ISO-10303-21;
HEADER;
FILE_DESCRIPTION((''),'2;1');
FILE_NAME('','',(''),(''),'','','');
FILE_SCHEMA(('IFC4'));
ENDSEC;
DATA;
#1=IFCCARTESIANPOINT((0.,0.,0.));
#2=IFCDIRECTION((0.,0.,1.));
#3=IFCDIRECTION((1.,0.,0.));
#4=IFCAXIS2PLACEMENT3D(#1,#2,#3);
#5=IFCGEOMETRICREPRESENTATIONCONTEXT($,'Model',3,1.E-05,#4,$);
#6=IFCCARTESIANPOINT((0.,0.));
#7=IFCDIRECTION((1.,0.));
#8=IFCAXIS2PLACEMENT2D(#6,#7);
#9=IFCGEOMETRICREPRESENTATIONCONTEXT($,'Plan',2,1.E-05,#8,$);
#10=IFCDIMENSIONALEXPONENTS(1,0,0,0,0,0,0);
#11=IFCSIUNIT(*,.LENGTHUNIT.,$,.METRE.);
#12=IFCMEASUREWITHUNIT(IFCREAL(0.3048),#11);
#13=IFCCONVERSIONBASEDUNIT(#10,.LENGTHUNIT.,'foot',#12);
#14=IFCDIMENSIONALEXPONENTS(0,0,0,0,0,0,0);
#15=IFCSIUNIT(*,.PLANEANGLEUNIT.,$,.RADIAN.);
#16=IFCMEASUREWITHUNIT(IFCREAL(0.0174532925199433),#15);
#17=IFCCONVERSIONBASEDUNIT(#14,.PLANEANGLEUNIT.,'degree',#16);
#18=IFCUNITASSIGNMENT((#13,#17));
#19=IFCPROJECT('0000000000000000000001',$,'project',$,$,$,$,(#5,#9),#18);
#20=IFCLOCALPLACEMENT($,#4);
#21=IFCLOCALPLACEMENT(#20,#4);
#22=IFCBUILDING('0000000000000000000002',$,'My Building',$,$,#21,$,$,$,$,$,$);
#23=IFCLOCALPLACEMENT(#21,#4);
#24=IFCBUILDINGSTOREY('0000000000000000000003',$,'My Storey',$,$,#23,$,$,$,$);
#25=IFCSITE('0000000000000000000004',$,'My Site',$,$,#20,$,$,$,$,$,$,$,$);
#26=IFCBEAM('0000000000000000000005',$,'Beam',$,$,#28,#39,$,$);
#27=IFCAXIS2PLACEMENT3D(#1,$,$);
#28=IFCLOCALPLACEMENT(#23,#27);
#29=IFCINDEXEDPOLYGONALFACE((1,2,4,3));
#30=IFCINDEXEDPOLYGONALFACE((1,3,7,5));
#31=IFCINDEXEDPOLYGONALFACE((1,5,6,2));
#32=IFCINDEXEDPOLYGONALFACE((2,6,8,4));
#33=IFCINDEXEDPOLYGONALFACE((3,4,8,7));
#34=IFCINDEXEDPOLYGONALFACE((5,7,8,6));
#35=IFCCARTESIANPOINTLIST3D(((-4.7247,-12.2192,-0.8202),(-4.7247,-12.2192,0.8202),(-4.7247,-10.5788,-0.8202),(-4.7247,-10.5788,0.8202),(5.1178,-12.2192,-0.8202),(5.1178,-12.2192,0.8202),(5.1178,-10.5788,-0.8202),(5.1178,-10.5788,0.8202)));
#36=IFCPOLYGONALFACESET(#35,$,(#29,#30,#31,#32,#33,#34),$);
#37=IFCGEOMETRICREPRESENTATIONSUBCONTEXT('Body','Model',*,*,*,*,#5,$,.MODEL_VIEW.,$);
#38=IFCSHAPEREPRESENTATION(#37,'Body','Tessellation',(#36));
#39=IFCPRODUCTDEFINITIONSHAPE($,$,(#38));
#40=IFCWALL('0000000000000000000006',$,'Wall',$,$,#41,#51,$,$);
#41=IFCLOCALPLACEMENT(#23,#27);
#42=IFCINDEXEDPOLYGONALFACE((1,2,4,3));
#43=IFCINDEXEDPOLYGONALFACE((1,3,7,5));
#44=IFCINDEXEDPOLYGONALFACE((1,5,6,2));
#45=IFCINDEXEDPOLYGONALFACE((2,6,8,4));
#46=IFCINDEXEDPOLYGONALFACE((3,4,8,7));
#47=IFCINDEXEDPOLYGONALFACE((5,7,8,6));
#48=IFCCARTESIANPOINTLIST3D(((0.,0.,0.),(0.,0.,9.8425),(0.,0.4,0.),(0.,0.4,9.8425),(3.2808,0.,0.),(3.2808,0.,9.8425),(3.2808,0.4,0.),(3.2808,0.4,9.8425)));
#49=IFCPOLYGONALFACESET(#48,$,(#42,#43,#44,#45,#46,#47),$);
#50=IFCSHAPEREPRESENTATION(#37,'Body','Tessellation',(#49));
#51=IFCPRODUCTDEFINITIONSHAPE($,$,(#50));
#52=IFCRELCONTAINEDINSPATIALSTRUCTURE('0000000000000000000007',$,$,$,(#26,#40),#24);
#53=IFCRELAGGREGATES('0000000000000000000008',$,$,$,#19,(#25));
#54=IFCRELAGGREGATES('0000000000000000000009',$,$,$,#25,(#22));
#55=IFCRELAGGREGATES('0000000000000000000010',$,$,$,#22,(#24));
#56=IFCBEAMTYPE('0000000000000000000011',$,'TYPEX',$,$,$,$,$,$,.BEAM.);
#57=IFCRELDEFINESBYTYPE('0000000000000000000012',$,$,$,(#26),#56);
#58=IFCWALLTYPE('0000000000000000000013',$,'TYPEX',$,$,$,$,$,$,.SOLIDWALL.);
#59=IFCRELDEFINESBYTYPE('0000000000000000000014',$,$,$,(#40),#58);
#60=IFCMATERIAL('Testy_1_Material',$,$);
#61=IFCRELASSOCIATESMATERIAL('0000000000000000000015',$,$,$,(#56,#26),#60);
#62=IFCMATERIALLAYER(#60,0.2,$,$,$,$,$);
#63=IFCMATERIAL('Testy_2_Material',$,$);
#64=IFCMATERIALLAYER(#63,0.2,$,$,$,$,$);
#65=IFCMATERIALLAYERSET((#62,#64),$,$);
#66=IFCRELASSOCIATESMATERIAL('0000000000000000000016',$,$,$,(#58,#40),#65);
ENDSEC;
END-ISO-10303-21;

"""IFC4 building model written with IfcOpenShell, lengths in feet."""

from ifc_helpers import new_model, entity, si_unit, converted_unit, frame, origin_with_axes, origin_2d_with_axis, place, context, subcontext, project, spatial, indexed_curve, rectangle, outline, extrude, material, layer, layer_set, layer_usage, material_profile, profile_set, profile_usage, type_object, element, save


model = new_model("IFC4")

# Units and contexts
model_context = context("Model", 3, precision=1e-05, world=origin_with_axes())
plan_context = context("Plan", 2, precision=1e-05, world=origin_2d_with_axis())
body_context = subcontext(model_context, "Body", "Model", "MODEL_VIEW")
ifc_project = project(units=[converted_unit("LENGTHUNIT", "foot", entity("IfcReal", 0.3048), si_unit("LENGTHUNIT", "METRE"), dimensions=[1, 0, 0, 0, 0, 0, 0]), converted_unit("PLANEANGLEUNIT", "degree", entity("IfcReal", 0.0174532925199433), si_unit("PLANEANGLEUNIT", "RADIAN"), dimensions=[0, 0, 0, 0, 0, 0, 0])], contexts=[model_context, plan_context])

# Site, building, storey
site_placement = place(None, origin_with_axes())
site = spatial("IfcSite", under=ifc_project, at=site_placement, Name="My Site")
building_placement = place(site_placement, origin_with_axes())
building = spatial("IfcBuilding", under=site, at=building_placement, Name="My Building")
storey_placement = place(building_placement, origin_with_axes())
storey = spatial("IfcBuildingStorey", under=building, at=storey_placement, Name="My Storey")

# Beam
ifc_material_1 = material(Name="Testy_1_Material")
ifc_material_profile = material_profile(ifc_material_1, rectangle(XDim=1.6404, YDim=1.6404))
ifc_profile_set = profile_set([ifc_material_profile])
ifc_profile_usage = profile_usage(ifc_profile_set, cardinal=5)
beam_type = type_object("IfcBeamType", Name="TYPEX", PredefinedType="BEAM", material=ifc_profile_set)
beam_placement = place(storey_placement, frame((-4.7247, -11.399, 0.0), z_axis=(1.0, 0.0, 0.0), x_axis=(0.0, 1.0, 0.0)))
element("IfcBeam", 1, at=beam_placement, inside=storey, type_object=beam_type, material=ifc_profile_usage, Name="Beam", context=body_context, shape_type="SweptSolid", body=[
    extrude(rectangle(XDim=1.6404, YDim=1.6404), origin_with_axes(), (0.0, 0.0, 1.0), 9.8425),
])

# Wall
ifc_layer_1 = layer(ifc_material_1, 0.2)
ifc_material_2 = material(Name="Testy_2_Material")
ifc_layer_2 = layer(ifc_material_2, 0.2)
ifc_layer_set = layer_set([ifc_layer_1, ifc_layer_2])
ifc_layer_usage = layer_usage(ifc_layer_set, "AXIS2", "POSITIVE", 0.0)
wall_type = type_object("IfcWallType", Name="TYPEX", PredefinedType="SOLIDWALL", material=ifc_layer_set)
wall_placement = place(storey_placement, origin_with_axes())
element("IfcWall", 2, at=wall_placement, inside=storey, type_object=wall_type, material=ifc_layer_usage, Name="Wall", context=body_context, shape_type="SweptSolid", body=[
    extrude(outline(indexed_curve([(0.0, 0.0), (0.0, 0.4), (3.2808, 0.4), (3.2808, 0.0), (0.0, 0.0)], self_intersect=False)), origin_with_axes(), (0.0, 0.0, 1.0), 9.8425),
])

save(model, "model.ifc")
